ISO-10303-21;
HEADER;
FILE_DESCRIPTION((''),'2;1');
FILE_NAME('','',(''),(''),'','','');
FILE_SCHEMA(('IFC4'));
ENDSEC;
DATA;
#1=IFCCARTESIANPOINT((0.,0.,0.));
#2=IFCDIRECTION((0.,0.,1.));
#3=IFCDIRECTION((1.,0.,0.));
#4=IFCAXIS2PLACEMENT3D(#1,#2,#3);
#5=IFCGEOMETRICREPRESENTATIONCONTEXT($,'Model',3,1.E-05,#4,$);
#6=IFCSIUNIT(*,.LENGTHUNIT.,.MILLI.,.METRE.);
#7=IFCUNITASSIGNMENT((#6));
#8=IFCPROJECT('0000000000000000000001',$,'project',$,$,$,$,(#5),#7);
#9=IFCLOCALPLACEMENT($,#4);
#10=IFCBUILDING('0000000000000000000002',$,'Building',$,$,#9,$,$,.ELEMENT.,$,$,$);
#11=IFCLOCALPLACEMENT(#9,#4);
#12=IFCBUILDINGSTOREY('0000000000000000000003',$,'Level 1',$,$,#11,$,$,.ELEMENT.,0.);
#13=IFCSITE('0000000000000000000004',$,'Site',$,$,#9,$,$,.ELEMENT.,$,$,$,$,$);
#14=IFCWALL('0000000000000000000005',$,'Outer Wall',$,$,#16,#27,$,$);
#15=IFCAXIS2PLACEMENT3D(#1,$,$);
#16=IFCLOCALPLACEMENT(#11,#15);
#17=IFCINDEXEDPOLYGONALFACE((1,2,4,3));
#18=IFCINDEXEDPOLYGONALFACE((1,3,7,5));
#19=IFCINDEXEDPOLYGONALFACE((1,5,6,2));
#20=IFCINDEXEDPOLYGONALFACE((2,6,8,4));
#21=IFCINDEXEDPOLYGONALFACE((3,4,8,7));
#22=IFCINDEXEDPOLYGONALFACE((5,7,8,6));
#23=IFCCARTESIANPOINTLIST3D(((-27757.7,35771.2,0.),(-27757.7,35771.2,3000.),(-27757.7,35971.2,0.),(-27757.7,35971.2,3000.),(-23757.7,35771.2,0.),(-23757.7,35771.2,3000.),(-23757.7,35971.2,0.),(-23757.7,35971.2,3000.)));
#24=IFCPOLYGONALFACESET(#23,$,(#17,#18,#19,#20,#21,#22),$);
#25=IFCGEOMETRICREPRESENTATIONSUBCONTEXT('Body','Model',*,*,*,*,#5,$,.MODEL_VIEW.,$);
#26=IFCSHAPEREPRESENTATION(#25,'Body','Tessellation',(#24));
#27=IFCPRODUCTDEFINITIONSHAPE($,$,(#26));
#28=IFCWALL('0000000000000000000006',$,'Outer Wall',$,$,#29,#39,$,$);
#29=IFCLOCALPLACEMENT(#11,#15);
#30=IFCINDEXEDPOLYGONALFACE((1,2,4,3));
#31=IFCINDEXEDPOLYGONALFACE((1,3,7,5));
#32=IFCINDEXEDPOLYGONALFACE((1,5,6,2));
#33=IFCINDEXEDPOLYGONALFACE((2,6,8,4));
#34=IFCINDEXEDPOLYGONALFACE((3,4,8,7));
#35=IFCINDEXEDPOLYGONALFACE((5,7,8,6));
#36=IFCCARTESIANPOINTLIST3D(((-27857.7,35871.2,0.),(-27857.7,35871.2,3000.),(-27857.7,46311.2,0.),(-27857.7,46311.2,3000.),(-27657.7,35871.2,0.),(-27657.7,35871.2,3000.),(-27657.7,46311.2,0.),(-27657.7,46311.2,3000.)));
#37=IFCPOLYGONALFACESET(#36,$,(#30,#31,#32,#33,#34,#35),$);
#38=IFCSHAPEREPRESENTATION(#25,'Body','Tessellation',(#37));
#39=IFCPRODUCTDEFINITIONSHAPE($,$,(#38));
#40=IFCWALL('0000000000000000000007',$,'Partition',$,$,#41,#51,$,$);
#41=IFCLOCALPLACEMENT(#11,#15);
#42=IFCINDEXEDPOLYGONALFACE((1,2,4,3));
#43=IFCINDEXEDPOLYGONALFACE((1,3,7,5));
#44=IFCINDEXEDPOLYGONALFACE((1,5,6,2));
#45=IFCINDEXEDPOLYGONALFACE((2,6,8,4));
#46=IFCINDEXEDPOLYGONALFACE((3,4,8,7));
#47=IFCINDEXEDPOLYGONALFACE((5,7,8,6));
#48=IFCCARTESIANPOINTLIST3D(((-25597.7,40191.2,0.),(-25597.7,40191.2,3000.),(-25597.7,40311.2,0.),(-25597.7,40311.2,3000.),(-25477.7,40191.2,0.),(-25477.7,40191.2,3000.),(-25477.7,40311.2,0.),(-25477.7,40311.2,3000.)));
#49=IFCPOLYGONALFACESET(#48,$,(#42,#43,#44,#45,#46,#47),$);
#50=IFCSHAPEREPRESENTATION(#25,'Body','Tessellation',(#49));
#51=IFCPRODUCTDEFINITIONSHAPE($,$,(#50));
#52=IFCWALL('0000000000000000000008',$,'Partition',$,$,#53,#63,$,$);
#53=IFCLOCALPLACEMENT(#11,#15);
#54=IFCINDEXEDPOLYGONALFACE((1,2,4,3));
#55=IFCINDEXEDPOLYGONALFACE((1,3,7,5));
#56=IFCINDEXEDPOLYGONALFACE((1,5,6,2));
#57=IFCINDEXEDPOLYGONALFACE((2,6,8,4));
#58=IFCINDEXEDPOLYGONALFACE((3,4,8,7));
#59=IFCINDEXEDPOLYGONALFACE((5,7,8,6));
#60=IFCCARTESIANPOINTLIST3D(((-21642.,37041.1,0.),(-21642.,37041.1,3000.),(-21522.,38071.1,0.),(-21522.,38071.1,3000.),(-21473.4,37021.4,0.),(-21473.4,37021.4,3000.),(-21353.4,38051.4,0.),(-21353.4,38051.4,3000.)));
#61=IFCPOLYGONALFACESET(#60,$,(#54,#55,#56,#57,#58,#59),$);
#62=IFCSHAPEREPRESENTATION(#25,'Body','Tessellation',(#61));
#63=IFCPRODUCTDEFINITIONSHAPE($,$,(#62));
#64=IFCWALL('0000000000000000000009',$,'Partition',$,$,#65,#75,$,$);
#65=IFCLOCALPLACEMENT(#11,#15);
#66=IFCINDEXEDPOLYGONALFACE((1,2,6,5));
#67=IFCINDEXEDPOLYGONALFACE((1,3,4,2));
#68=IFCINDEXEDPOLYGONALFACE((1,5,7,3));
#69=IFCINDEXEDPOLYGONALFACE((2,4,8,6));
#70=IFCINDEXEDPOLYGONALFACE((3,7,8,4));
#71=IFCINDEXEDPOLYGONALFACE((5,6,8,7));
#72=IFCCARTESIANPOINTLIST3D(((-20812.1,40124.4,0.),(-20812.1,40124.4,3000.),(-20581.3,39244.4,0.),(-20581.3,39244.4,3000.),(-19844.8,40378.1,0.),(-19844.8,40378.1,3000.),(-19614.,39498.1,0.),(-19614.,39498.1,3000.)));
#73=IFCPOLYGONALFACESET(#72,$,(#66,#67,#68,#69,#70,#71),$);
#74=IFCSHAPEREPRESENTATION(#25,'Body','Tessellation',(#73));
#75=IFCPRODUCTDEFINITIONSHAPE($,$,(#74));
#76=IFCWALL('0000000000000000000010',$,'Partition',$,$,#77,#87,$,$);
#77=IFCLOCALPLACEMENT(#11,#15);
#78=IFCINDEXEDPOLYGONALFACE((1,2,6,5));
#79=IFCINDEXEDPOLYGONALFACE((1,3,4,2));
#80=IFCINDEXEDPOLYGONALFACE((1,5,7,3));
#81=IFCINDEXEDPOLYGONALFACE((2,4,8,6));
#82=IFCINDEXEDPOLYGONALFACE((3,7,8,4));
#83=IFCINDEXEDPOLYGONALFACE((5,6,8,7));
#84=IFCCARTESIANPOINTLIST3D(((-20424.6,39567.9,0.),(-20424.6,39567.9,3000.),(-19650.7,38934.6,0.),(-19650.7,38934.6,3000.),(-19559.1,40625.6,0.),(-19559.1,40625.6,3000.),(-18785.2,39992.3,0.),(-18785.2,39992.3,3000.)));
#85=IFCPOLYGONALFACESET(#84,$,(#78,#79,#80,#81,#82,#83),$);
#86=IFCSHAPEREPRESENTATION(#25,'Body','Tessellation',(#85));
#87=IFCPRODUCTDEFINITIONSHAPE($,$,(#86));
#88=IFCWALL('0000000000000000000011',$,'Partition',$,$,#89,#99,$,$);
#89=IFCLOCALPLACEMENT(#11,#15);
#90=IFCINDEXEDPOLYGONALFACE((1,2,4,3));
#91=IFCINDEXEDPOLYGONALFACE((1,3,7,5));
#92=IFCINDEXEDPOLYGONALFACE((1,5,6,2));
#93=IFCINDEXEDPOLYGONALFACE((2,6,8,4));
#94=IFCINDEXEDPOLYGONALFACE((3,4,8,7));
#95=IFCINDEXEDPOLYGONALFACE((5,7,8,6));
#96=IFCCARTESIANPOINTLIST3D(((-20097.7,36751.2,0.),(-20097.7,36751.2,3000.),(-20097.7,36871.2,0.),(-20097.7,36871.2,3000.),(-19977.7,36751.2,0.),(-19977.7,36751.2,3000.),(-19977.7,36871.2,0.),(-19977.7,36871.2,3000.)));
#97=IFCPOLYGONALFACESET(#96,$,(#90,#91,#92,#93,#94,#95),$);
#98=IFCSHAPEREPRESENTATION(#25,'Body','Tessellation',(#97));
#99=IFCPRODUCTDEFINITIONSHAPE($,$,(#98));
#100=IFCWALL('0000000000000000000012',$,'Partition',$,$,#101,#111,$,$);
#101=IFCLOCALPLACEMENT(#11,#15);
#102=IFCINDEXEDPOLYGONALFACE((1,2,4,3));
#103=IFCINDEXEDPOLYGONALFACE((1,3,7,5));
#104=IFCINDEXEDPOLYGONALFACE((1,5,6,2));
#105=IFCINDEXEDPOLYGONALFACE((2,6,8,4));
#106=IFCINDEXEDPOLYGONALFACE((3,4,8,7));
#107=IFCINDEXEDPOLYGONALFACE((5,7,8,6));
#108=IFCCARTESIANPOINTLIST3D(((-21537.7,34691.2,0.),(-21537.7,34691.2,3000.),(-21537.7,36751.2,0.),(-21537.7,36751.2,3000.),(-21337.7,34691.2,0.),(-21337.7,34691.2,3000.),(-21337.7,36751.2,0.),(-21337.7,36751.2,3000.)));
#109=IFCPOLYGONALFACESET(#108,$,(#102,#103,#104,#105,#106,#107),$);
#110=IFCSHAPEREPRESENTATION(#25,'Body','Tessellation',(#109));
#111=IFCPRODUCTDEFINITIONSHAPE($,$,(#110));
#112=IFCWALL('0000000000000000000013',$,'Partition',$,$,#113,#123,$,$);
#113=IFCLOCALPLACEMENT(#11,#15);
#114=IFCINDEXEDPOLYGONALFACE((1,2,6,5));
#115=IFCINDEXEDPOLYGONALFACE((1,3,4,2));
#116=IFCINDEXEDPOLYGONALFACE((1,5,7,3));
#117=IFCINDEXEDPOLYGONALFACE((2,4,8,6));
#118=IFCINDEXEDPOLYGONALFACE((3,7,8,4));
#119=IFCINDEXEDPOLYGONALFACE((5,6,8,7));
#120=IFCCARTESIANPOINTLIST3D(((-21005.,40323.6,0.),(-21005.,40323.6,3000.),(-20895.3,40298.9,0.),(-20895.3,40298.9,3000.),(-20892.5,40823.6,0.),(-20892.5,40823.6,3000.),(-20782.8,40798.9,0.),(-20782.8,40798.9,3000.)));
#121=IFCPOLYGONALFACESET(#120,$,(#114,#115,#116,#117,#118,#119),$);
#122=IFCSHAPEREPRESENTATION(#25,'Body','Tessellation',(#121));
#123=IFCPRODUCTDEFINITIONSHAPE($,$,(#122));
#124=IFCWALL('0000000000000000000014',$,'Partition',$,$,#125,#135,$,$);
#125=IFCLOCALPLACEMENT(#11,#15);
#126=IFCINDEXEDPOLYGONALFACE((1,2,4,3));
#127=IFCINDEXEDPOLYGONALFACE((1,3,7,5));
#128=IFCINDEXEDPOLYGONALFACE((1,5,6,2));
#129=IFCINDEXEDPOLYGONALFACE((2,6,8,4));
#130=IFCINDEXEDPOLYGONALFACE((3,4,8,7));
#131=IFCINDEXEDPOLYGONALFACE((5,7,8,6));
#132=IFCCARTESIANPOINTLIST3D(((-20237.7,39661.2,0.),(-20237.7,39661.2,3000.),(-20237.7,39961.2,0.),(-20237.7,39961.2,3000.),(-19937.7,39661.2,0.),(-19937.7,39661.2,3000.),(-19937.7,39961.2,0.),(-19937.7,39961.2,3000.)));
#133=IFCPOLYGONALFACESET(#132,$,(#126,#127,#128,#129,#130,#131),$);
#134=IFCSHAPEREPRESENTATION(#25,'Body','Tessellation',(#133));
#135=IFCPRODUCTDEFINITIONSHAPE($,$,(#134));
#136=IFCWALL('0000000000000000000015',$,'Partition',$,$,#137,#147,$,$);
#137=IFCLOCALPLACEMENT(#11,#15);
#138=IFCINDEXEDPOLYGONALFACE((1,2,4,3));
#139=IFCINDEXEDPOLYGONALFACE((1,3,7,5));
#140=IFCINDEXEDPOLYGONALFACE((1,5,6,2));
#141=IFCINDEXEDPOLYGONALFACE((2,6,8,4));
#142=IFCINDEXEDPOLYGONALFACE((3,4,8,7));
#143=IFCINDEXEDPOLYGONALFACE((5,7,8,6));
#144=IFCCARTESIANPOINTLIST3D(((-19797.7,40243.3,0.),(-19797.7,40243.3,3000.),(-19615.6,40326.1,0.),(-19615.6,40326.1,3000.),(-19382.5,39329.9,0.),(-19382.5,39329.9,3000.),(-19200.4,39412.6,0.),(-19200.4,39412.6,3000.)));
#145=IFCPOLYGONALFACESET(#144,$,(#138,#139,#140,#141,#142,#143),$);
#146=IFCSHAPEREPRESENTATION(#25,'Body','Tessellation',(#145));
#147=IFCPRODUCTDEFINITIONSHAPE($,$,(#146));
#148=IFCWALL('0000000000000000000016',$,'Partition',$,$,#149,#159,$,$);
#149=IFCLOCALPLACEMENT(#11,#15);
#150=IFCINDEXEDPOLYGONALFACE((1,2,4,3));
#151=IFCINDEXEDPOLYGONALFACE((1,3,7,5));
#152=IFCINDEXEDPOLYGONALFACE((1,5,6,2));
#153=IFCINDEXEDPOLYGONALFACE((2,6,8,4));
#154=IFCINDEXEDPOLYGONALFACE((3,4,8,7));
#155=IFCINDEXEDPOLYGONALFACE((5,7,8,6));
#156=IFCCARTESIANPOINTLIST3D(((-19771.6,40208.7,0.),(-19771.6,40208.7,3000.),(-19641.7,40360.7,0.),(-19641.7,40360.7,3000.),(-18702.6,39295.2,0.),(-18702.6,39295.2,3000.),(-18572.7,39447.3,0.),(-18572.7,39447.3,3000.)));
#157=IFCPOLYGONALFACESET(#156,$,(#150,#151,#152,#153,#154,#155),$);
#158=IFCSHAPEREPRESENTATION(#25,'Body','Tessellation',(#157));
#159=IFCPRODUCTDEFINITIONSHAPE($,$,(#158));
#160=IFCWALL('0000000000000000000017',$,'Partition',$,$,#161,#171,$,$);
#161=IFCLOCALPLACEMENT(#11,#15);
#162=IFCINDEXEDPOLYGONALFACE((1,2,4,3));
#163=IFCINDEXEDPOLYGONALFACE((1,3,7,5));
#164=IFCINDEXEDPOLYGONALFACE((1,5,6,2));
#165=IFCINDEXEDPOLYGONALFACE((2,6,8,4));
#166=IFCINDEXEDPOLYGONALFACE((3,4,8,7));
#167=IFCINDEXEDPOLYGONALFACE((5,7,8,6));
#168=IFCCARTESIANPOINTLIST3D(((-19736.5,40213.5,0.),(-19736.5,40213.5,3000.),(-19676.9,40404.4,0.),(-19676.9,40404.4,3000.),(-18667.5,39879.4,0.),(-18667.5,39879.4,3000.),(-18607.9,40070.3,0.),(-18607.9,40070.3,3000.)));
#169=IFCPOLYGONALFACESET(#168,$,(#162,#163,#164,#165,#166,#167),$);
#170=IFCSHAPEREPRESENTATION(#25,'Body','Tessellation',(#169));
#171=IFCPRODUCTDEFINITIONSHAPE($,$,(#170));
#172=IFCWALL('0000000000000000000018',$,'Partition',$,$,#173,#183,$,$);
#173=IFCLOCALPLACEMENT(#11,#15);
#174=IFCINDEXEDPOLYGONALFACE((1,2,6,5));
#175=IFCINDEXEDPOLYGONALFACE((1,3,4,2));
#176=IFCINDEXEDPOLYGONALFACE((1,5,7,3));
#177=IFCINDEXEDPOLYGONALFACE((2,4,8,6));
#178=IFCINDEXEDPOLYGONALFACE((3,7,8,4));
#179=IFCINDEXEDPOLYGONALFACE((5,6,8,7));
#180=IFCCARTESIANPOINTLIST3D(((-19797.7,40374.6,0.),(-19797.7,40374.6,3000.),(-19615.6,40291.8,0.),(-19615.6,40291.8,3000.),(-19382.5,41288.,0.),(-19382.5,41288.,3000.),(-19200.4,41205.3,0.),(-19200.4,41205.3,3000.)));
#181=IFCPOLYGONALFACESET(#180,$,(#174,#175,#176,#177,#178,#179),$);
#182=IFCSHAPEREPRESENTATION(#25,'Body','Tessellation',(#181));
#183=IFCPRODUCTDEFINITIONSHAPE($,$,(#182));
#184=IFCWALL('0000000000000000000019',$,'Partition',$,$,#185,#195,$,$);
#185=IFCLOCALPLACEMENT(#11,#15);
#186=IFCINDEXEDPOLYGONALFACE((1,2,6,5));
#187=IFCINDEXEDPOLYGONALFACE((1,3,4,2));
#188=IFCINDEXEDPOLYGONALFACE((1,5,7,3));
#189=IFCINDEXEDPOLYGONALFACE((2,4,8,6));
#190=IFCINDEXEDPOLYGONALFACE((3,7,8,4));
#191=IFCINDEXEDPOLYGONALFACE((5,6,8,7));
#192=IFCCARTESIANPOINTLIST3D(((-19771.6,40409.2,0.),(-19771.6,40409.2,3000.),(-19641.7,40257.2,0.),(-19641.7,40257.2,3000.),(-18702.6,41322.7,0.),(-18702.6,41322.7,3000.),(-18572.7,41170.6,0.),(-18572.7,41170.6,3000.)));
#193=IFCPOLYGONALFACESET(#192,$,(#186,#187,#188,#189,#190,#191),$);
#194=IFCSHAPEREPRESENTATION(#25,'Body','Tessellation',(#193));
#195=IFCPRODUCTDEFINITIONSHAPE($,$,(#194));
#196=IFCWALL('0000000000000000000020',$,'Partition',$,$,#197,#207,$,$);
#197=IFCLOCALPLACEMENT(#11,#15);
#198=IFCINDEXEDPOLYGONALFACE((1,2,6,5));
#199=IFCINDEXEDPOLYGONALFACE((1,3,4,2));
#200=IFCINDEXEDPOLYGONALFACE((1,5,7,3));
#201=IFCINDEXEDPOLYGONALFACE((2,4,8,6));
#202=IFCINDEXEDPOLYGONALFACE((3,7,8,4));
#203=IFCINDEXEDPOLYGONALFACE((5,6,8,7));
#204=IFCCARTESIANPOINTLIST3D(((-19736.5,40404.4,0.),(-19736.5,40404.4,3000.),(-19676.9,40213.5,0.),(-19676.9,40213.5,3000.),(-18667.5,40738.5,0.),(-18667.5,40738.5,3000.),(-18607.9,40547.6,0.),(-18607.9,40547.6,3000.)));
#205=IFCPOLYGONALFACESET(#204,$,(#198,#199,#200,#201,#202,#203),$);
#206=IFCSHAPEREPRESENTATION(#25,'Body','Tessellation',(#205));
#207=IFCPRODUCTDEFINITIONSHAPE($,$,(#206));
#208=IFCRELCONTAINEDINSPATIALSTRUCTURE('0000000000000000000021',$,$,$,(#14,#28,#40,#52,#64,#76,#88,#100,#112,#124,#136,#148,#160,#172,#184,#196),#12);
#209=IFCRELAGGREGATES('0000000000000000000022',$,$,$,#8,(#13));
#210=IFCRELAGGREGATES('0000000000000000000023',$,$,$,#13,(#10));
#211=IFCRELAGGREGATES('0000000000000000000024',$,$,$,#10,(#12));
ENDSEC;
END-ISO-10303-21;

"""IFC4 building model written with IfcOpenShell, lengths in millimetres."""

from ifc_helpers import new_model, si_unit, frame, frame_2d, origin_with_axes, place, context, subcontext, project, spatial, rectangle, extrude, element, save


model = new_model("IFC4")

# Units and contexts
model_context = context("Model", 3, precision=1e-05, world=origin_with_axes())
body_context = subcontext(model_context, "Body", "Model", "MODEL_VIEW")
ifc_project = project(units=[si_unit("LENGTHUNIT", "METRE", prefix="MILLI")], contexts=[model_context])

# Site, building, storey
placement = place(None, origin_with_axes())
site = spatial("IfcSite", under=ifc_project, at=placement, Name="Site", CompositionType="ELEMENT")
building = spatial("IfcBuilding", under=site, at=placement, Name="Building", CompositionType="ELEMENT")
storey_placement = place(placement, origin_with_axes())
storey = spatial("IfcBuildingStorey", under=building, at=storey_placement, Name="Level 1", CompositionType="ELEMENT", Elevation=0.0)

# Walls
wall_1_placement = place(placement, frame((-23757.7, 35871.2, 0.0), z_axis=(0.0, 0.0, 1.0), x_axis=(-1.0, 0.0, 0.0)))
element("IfcWall", 1, at=wall_1_placement, inside=storey, Name="Outer Wall", context=body_context, shape_type="SweptSolid", body=[
    extrude(rectangle(XDim=4000.0, YDim=200.0, at=frame_2d((2000.0, 0.0), x_axis=(1.0, 0.0))), origin_with_axes(), (0.0, 0.0, 1.0), 3000.0),
])
wall_2_placement = place(placement, frame((-27757.7, 35871.2, 0.0), z_axis=(0.0, 0.0, 1.0), x_axis=(0.0, 1.0, 0.0)))
element("IfcWall", 2, at=wall_2_placement, inside=storey, Name="Outer Wall", context=body_context, shape_type="SweptSolid", body=[
    extrude(rectangle(XDim=10440.0, YDim=200.0, at=frame_2d((5220.0, 0.0), x_axis=(1.0, 0.0))), origin_with_axes(), (0.0, 0.0, 1.0), 3000.0),
])
wall_3_placement = place(placement, frame((-25537.7, 40191.2, 0.0), z_axis=(0.0, 0.0, 1.0), x_axis=(0.0, 1.0, 0.0)))
element("IfcWall", 3, at=wall_3_placement, inside=storey, Name="Partition", context=body_context, shape_type="SweptSolid", body=[
    extrude(rectangle(XDim=120.0, YDim=120.0, at=frame_2d((60.0, 0.0), x_axis=(1.0, 0.0))), origin_with_axes(), (0.0, 0.0, 1.0), 3000.0),
])
wall_4_placement = place(placement, frame((-21557.7, 37031.2, 0.0), z_axis=(0.0, 0.0, 1.0), x_axis=(0.115722, 0.993282, 0.0)))
element("IfcWall", 4, at=wall_4_placement, inside=storey, Name="Partition", context=body_context, shape_type="SweptSolid", body=[
    extrude(rectangle(XDim=1037.0, YDim=169.7, at=frame_2d((518.5, 0.0), x_axis=(1.0, 0.0))), origin_with_axes(), (0.0, 0.0, 1.0), 3000.0),
])
wall_5_placement = place(placement, frame((-20328.4, 40251.2, 0.0), z_axis=(0.0, 0.0, 1.0), x_axis=(0.253619, -0.967304, 0.0)))
element("IfcWall", 5, at=wall_5_placement, inside=storey, Name="Partition", context=body_context, shape_type="SweptSolid", body=[
    extrude(rectangle(XDim=909.7, YDim=1000.0, at=frame_2d((454.9, 0.0), x_axis=(1.0, 0.0))), origin_with_axes(), (0.0, 0.0, 1.0), 3000.0),
])
wall_6_placement = place(placement, frame((-20037.7, 39251.2, 0.0), z_axis=(0.0, 0.0, 1.0), x_axis=(0.633284, 0.77392, 0.0)))
element("IfcWall", 6, at=wall_6_placement, inside=storey, Name="Partition", context=body_context, shape_type="SweptSolid", body=[
    extrude(rectangle(XDim=1366.7, YDim=1000.0, at=frame_2d((683.3, 0.0), x_axis=(1.0, 0.0))), origin_with_axes(), (0.0, 0.0, 1.0), 3000.0),
])
wall_7_placement = place(placement, frame((-20037.7, 36871.2, 0.0), z_axis=(0.0, 0.0, 1.0), x_axis=(0.0, -1.0, 0.0)))
element("IfcWall", 7, at=wall_7_placement, inside=storey, Name="Partition", context=body_context, shape_type="SweptSolid", body=[
    extrude(rectangle(XDim=120.0, YDim=120.0, at=frame_2d((60.0, 0.0), x_axis=(1.0, 0.0))), origin_with_axes(), (0.0, 0.0, 1.0), 3000.0),
])
wall_8_placement = place(placement, frame((-21437.7, 36751.2, 0.0), z_axis=(0.0, 0.0, 1.0), x_axis=(0.0, -1.0, 0.0)))
element("IfcWall", 8, at=wall_8_placement, inside=storey, Name="Partition", context=body_context, shape_type="SweptSolid", body=[
    extrude(rectangle(XDim=2060.0, YDim=200.0, at=frame_2d((1030.0, 0.0), x_axis=(1.0, 0.0))), origin_with_axes(), (0.0, 0.0, 1.0), 3000.0),
])
wall_9_placement = place(placement, frame((-20950.1, 40311.2, 0.0), z_axis=(0.0, 0.0, 1.0), x_axis=(0.219438, 0.975626, 0.0)))
element("IfcWall", 9, at=wall_9_placement, inside=storey, Name="Partition", context=body_context, shape_type="SweptSolid", body=[
    extrude(rectangle(XDim=512.5, YDim=112.5, at=frame_2d((256.2, 0.0), x_axis=(1.0, 0.0))), origin_with_axes(), (0.0, 0.0, 1.0), 3000.0),
])
wall_10_placement = place(placement, frame((-20237.7, 39811.2, 0.0), z_axis=(0.0, 0.0, 1.0), x_axis=(1.0, 0.0, 0.0)))
element("IfcWall", 10, at=wall_10_placement, inside=storey, Name="Partition", context=body_context, shape_type="SweptSolid", body=[
    extrude(rectangle(XDim=300.0, YDim=300.0, at=frame_2d((150.0, 0.0), x_axis=(1.0, 0.0))), origin_with_axes(), (0.0, 0.0, 1.0), 3000.0),
])
wall_11_placement = place(placement, frame((-19706.7, 40284.7, 0.0), z_axis=(0.0, 0.0, 1.0), x_axis=(0.413803, -0.910366, 0.0)))
element("IfcWall", 11, at=wall_11_placement, inside=storey, Name="Partition", context=body_context, shape_type="SweptSolid", body=[
    extrude(rectangle(XDim=1003.4, YDim=200.0, at=frame_2d((501.7, 0.0), x_axis=(1.0, 0.0))), origin_with_axes(), (0.0, 0.0, 1.0), 3000.0),
])
wall_12_placement = place(placement, frame((-19706.7, 40284.7, 0.0), z_axis=(0.0, 0.0, 1.0), x_axis=(0.760255, -0.649625, 0.0)))
element("IfcWall", 12, at=wall_12_placement, inside=storey, Name="Partition", context=body_context, shape_type="SweptSolid", body=[
    extrude(rectangle(XDim=1406.1, YDim=200.0, at=frame_2d((703.1, 0.0), x_axis=(1.0, 0.0))), origin_with_axes(), (0.0, 0.0, 1.0), 3000.0),
])
wall_13_placement = place(placement, frame((-19706.7, 40309.0, 0.0), z_axis=(0.0, 0.0, 1.0), x_axis=(0.95447, -0.298306, 0.0)))
element("IfcWall", 13, at=wall_13_placement, inside=storey, Name="Partition", context=body_context, shape_type="SweptSolid", body=[
    extrude(rectangle(XDim=1120.0, YDim=200.0, at=frame_2d((560.0, 0.0), x_axis=(1.0, 0.0))), origin_with_axes(), (0.0, 0.0, 1.0), 3000.0),
])
wall_14_placement = place(placement, frame((-19706.7, 40333.2, 0.0), z_axis=(0.0, 0.0, 1.0), x_axis=(0.413803, 0.910366, 0.0)))
element("IfcWall", 14, at=wall_14_placement, inside=storey, Name="Partition", context=body_context, shape_type="SweptSolid", body=[
    extrude(rectangle(XDim=1003.4, YDim=200.0, at=frame_2d((501.7, 0.0), x_axis=(1.0, 0.0))), origin_with_axes(), (0.0, 0.0, 1.0), 3000.0),
])
wall_15_placement = place(placement, frame((-19706.7, 40333.2, 0.0), z_axis=(0.0, 0.0, 1.0), x_axis=(0.760255, 0.649625, 0.0)))
element("IfcWall", 15, at=wall_15_placement, inside=storey, Name="Partition", context=body_context, shape_type="SweptSolid", body=[
    extrude(rectangle(XDim=1406.1, YDim=200.0, at=frame_2d((703.1, 0.0), x_axis=(1.0, 0.0))), origin_with_axes(), (0.0, 0.0, 1.0), 3000.0),
])
wall_16_placement = place(placement, frame((-19706.7, 40309.0, 0.0), z_axis=(0.0, 0.0, 1.0), x_axis=(0.95447, 0.298306, 0.0)))
element("IfcWall", 16, at=wall_16_placement, inside=storey, Name="Partition", context=body_context, shape_type="SweptSolid", body=[
    extrude(rectangle(XDim=1120.0, YDim=200.0, at=frame_2d((560.0, 0.0), x_axis=(1.0, 0.0))), origin_with_axes(), (0.0, 0.0, 1.0), 3000.0),
])

save(model, "model.ifc")
